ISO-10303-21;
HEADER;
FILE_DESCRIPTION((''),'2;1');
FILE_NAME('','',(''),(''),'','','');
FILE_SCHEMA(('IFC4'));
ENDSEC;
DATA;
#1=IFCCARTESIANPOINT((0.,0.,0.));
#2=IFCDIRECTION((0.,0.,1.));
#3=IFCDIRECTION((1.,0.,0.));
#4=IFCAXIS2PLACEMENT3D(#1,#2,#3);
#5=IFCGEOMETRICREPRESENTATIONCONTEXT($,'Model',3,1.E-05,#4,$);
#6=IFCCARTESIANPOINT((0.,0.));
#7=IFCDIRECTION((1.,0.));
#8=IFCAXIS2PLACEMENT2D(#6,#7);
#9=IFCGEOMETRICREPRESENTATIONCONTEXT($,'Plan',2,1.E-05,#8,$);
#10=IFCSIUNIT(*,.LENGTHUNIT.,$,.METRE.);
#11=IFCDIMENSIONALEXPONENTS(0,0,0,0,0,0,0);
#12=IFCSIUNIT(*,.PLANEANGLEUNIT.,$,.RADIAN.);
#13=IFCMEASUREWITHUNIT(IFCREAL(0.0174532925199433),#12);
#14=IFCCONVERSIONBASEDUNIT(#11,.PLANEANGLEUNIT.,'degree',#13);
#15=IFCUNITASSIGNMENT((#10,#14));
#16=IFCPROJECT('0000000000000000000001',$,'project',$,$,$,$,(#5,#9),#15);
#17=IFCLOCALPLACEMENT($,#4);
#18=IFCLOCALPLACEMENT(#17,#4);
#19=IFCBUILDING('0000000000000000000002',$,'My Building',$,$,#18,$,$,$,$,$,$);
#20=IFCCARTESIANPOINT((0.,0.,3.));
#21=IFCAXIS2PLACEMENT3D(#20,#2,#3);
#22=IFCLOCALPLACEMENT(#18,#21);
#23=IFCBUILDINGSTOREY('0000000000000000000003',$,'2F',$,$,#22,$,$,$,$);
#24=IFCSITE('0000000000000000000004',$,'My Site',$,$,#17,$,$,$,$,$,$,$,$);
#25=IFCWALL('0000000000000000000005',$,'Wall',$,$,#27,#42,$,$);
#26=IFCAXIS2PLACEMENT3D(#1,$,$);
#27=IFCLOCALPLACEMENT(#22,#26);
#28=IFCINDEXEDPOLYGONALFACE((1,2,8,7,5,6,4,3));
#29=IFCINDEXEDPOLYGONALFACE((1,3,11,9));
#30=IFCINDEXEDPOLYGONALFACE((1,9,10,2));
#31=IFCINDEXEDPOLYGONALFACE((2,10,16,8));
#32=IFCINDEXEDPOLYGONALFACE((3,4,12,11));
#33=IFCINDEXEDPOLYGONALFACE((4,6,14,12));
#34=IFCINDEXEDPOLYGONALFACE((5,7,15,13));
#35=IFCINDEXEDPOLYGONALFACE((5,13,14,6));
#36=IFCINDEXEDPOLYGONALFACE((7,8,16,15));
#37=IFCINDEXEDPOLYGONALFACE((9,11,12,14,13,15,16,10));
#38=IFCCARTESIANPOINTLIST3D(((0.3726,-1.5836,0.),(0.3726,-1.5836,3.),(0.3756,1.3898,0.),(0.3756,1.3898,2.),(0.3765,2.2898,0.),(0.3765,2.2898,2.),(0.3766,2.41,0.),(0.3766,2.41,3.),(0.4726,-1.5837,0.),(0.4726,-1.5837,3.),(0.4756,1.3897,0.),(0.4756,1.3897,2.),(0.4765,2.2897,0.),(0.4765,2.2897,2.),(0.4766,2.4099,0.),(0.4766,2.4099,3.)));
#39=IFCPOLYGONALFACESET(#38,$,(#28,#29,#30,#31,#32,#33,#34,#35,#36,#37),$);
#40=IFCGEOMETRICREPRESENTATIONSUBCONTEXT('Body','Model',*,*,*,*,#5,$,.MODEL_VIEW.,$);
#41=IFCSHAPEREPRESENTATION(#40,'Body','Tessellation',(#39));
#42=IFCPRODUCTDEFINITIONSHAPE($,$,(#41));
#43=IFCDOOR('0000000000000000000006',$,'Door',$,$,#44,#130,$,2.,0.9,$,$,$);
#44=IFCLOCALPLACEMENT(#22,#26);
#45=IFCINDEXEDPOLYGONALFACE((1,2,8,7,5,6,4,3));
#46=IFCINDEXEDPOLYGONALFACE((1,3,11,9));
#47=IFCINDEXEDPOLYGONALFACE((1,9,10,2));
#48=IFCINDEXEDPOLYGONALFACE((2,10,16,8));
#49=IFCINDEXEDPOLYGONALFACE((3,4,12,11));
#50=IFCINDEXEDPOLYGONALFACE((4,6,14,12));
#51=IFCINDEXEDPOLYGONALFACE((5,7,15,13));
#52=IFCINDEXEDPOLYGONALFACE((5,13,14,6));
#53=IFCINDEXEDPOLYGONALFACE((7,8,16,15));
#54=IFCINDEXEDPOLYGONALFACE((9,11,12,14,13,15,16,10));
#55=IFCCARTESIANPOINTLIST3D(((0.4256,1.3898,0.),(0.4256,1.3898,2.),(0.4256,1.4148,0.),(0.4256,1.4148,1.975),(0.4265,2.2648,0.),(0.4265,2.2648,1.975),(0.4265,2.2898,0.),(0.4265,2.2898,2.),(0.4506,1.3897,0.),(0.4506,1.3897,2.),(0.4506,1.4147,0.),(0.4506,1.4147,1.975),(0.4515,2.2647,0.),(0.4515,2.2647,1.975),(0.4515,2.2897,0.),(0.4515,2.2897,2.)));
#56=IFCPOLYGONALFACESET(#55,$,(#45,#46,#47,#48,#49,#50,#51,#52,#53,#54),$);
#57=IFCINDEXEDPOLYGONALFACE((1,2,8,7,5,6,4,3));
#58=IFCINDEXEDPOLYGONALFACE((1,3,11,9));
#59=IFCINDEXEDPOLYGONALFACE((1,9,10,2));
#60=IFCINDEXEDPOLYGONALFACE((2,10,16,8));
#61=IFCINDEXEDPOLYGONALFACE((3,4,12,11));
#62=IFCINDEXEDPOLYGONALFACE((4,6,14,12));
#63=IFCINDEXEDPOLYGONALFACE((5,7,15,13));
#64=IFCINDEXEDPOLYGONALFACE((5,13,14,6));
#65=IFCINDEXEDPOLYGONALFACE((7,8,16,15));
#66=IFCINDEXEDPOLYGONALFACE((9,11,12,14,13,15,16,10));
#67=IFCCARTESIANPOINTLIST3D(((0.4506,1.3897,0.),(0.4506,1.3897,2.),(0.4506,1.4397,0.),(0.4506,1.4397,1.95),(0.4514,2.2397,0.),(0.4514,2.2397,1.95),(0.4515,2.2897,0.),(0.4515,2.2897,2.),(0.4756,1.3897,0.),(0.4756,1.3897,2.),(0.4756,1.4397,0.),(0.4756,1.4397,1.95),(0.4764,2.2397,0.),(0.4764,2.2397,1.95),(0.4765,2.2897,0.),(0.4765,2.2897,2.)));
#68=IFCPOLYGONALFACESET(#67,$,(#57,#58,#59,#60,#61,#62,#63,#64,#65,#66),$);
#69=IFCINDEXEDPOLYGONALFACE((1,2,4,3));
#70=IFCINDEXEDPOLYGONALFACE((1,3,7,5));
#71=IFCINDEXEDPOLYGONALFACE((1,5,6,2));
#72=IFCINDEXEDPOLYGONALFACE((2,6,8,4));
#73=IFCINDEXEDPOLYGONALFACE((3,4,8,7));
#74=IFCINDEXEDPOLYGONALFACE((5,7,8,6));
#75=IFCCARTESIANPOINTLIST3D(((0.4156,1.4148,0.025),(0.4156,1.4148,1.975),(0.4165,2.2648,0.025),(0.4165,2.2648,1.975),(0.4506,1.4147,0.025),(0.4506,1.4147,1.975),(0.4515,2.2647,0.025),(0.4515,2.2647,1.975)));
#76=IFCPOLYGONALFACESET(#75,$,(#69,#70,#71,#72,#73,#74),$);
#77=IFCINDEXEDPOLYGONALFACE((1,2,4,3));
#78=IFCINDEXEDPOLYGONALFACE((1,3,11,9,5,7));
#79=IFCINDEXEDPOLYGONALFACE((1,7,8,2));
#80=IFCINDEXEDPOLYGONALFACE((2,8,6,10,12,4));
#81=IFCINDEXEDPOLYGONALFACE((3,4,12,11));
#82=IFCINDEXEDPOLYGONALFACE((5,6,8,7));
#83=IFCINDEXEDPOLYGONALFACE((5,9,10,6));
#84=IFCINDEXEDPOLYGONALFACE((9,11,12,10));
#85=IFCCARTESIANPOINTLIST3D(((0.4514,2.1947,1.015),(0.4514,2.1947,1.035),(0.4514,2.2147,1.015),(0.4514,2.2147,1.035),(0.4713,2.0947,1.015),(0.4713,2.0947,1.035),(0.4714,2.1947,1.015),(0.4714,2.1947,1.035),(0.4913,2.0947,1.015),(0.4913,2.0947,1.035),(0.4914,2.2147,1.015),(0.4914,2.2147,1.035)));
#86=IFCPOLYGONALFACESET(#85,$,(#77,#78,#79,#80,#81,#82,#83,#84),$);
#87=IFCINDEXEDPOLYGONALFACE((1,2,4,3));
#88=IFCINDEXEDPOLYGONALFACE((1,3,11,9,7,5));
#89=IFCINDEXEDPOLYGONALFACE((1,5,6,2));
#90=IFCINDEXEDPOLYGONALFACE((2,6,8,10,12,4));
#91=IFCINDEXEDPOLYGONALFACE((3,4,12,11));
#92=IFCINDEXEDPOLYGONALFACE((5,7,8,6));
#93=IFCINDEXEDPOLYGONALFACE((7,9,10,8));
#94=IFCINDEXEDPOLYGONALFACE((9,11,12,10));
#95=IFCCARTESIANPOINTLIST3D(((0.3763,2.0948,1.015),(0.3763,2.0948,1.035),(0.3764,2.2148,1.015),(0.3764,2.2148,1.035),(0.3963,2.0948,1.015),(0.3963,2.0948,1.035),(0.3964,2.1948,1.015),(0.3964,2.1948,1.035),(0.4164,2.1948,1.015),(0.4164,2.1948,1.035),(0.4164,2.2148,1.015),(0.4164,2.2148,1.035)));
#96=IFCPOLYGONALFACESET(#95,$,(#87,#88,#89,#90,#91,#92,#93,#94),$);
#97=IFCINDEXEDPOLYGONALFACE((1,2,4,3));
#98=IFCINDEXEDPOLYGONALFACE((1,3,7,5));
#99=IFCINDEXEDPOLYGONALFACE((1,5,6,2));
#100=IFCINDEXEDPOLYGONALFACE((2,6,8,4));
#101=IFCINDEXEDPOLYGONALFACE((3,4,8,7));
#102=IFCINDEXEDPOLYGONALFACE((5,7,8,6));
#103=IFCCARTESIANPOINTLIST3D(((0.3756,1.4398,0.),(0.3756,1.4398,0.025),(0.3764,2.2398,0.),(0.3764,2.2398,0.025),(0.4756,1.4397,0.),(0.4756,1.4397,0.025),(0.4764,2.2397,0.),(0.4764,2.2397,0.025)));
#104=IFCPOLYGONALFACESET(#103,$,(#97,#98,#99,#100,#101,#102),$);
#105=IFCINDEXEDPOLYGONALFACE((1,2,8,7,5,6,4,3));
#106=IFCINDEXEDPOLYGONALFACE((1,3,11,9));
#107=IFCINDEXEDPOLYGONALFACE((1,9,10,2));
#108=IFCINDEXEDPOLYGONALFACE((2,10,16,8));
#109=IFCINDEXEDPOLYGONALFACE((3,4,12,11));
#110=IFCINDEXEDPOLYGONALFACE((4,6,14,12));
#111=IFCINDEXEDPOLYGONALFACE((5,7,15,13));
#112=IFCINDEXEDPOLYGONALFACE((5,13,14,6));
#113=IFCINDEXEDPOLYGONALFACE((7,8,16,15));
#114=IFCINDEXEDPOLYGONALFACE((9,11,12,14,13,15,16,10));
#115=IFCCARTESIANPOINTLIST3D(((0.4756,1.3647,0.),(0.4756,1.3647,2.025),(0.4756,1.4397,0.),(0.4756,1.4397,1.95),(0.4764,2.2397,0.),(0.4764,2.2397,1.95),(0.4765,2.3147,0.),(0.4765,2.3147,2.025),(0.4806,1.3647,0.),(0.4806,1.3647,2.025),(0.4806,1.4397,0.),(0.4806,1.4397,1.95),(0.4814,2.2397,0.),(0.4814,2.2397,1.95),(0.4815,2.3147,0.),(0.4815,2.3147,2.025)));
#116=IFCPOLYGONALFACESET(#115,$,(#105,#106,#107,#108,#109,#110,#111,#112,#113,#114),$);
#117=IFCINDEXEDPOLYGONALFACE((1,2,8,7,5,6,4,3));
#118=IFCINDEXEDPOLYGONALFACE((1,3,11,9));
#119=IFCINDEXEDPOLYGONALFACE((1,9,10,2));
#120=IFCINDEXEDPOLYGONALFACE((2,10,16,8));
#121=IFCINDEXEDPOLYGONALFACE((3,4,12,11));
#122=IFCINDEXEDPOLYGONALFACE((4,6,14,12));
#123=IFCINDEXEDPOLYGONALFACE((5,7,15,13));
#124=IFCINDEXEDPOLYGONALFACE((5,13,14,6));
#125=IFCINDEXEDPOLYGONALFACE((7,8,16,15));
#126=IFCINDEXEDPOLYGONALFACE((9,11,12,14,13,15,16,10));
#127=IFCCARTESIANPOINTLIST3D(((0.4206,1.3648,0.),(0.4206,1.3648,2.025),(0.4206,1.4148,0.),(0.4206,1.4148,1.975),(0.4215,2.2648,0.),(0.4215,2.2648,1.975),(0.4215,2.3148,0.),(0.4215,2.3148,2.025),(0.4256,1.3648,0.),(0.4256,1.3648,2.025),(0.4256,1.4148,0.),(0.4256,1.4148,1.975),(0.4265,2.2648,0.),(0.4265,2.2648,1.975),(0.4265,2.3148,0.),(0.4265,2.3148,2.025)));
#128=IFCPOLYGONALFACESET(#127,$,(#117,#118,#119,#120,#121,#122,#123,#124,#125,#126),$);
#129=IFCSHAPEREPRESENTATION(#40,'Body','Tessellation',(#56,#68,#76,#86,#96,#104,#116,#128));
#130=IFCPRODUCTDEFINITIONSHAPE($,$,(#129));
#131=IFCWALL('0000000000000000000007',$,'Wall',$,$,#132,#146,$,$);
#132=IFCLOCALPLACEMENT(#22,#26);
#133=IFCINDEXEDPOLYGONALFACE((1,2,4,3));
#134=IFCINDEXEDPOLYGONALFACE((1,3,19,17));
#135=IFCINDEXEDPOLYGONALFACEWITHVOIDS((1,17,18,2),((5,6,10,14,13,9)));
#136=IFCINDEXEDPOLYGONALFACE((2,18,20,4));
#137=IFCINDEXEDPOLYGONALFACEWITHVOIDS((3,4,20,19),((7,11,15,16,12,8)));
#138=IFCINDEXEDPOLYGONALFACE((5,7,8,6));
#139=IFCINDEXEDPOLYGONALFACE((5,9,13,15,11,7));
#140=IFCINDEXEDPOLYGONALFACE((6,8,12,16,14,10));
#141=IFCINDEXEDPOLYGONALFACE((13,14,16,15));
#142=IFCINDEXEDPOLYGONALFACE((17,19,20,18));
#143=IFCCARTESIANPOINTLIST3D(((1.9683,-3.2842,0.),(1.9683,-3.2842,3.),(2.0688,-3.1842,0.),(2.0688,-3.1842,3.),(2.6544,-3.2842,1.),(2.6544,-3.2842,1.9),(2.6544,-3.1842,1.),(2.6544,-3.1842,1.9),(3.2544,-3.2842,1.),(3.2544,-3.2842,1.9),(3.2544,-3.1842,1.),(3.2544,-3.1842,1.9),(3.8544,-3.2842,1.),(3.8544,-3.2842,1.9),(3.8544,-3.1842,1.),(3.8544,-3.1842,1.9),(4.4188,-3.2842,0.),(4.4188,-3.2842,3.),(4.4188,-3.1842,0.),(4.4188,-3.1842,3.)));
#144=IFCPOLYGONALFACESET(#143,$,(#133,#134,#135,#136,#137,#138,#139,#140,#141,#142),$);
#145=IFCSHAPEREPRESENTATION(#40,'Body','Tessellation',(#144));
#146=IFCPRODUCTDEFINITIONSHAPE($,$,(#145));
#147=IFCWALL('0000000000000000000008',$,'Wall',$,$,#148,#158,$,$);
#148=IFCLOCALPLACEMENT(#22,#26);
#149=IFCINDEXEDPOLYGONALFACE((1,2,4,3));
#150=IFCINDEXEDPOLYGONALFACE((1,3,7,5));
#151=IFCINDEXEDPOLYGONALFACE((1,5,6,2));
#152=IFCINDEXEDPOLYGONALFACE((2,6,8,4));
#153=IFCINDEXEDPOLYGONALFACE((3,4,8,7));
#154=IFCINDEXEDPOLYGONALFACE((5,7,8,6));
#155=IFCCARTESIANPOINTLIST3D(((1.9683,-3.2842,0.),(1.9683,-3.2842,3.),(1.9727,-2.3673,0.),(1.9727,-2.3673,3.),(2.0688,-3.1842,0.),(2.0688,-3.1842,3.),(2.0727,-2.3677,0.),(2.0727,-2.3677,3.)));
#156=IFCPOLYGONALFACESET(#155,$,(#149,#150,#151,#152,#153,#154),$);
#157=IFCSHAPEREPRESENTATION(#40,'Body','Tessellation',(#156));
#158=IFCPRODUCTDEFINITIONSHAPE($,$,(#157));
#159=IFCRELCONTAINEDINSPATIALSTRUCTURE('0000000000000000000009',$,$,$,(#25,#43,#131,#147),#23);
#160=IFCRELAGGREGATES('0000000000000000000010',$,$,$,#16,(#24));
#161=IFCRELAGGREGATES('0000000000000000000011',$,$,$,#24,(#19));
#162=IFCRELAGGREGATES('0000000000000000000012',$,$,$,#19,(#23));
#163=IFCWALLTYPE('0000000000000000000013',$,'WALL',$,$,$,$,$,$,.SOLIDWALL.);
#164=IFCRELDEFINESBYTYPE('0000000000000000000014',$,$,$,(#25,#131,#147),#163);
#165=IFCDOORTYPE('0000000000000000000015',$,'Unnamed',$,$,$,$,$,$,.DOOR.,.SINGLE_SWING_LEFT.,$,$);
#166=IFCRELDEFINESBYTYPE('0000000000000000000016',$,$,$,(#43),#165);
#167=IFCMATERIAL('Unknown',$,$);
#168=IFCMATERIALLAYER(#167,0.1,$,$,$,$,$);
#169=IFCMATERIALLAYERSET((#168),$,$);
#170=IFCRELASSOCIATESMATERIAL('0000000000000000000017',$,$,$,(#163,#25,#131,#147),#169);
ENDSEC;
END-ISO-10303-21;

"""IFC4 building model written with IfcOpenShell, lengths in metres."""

from ifc_helpers import new_model, entity, si_unit, converted_unit, frame, origin_with_axes, origin_2d_with_axis, place, context, subcontext, project, spatial, line, indexed_curve, outline, extrude, shape, source, transform, mapped, material, layer, layer_set, layer_usage, type_object, type_shapes, element, fill, save


model = new_model("IFC4")

# Units and contexts
model_context = context("Model", 3, precision=1e-05, world=origin_with_axes())
plan_context = context("Plan", 2, precision=1e-05, world=origin_2d_with_axis())
body_context_1 = subcontext(model_context, "Body", "Model", "MODEL_VIEW")
body_context_2 = subcontext(plan_context, "Body", "Plan", "PLAN_VIEW")
ifc_project = project(units=[si_unit("LENGTHUNIT", "METRE"), converted_unit("PLANEANGLEUNIT", "degree", entity("IfcReal", 0.0174532925199433), si_unit("PLANEANGLEUNIT", "RADIAN"), dimensions=[0, 0, 0, 0, 0, 0, 0])], contexts=[model_context, plan_context])

# Site, building, storey
site_placement = place(None, origin_with_axes())
site = spatial("IfcSite", under=ifc_project, at=site_placement, Name="My Site")
building_placement = place(site_placement, origin_with_axes())
building = spatial("IfcBuilding", under=site, at=building_placement, Name="My Building")
storey_placement = place(building_placement, frame((0.0, 0.0, 3.0), z_axis=(0.0, 0.0, 1.0), x_axis=(1.0, 0.0, 0.0)))
storey = spatial("IfcBuildingStorey", under=building, at=storey_placement, Name="2F")

# Shared definitions
ifc_material = material(Name="Unknown")

# Shared definitions
ifc_layer = layer(ifc_material, 0.1)
ifc_layer_set = layer_set([ifc_layer])
wall_type = type_object("IfcWallType", Name="WALL", PredefinedType="SOLIDWALL", material=ifc_layer_set)

# Wall, opening, door
ifc_layer_usage_1 = layer_usage(ifc_layer_set, "AXIS2", "POSITIVE", 0.0)
wall_1_placement = place(storey_placement, frame((0.4726, -1.5837, 0.0), z_axis=(0.0, 0.0, 1.0), x_axis=(0.000991, 1.0, 0.0)))
wall_1 = element("IfcWall", 1, at=wall_1_placement, inside=storey, type_object=wall_type, material=ifc_layer_usage_1, Name="Wall", context=body_context_1, shape_type="SweptSolid", body=[
    extrude(outline(indexed_curve([(0.0, 0.0), (0.0, 0.1), (3.9936, 0.1), (3.9936, 0.0)], segments=[line(1, 2, 3, 4, 1)])), origin_with_axes(), (0.0, 0.0, 1.0), 3.0),
])
shared_shape_1 = source(origin_with_axes(), body_context_1, "Body", "SweptSolid", [
    extrude(outline(indexed_curve([(0.0, 0.0), (0.9, 0.0), (0.9, 2.0), (0.0, 2.0)], segments=[line(1, 2, 3, 4, 1)])), frame((0.0, -0.6, 0.0), z_axis=(0.0, -1.0, 0.0), x_axis=(1.0, 0.0, 0.0)), (0.0, 0.0, -1.0), 1.2),
])
opening_1_placement = place(wall_1_placement, frame((2.9734, 0.0, 0.0), z_axis=(0.0, 0.0, 1.0), x_axis=(1.0, 0.0, 0.0)))
opening_1 = element("IfcOpeningElement", 2, at=opening_1_placement, cuts=wall_1, PredefinedType="OPENING", context=body_context_1, shape_type="MappedRepresentation", body=[
    mapped(shared_shape_1, transform((0.0, 0.0, 0.0), x_axis=(1.0, 0.0, 0.0), y_axis=(0.0, 1.0, 0.0), z_axis=(0.0, 0.0, 1.0), scale=1.0)),
])
door_type = type_object("IfcDoorType", Name="Unnamed", OperationType="SINGLE_SWING_LEFT", PredefinedType="DOOR")
shared_shape_2 = source(origin_with_axes(), body_context_1, "Body", "SweptSolid", [
    extrude(outline(indexed_curve([(0.0, 0.0), (0.0, 2.0), (0.9, 2.0), (0.9, 0.0), (0.875, 0.0), (0.875, 1.975), (0.025, 1.975), (0.025, 0.0)], segments=[line(1, 2, 3, 4, 5, 6, 7, 8, 1)])), frame((0.0, 0.025, 0.0), z_axis=(0.0, -1.0, 0.0), x_axis=(1.0, 0.0, 0.0)), (0.0, 0.0, -1.0), 0.025),
    extrude(outline(indexed_curve([(0.0, 0.0), (0.0, 2.0), (0.9, 2.0), (0.9, 0.0), (0.85, 0.0), (0.85, 1.95), (0.05, 1.95), (0.05, 0.0)], segments=[line(1, 2, 3, 4, 5, 6, 7, 8, 1)])), frame((0.0, 0.0, 0.0), z_axis=(0.0, -1.0, 0.0), x_axis=(1.0, 0.0, 0.0)), (0.0, 0.0, -1.0), 0.025),
    extrude(outline(indexed_curve([(0.0, 0.0), (0.85, 0.0), (0.85, 0.035), (0.0, 0.035)], segments=[line(1, 2, 3, 4, 1)])), frame((0.025, 0.025, 0.025), z_axis=(0.0, 0.0, 1.0), x_axis=(1.0, 0.0, 0.0)), (0.0, 0.0, 1.0), 1.95),
    extrude(outline(indexed_curve([(0.0, 0.0), (0.0, -0.04), (-0.12, -0.04), (-0.12, -0.02), (-0.02, -0.02), (-0.02, 0.0)], segments=[line(1, 2, 3, 4, 5, 6, 1)])), frame((0.825, 0.025, 1.015), z_axis=(0.0, 0.0, 1.0), x_axis=(1.0, 0.0, 0.0)), (0.0, 0.0, 1.0), 0.02),
    extrude(outline(indexed_curve([(0.0, 0.0), (0.0, 0.04), (-0.12, 0.04), (-0.12, 0.02), (-0.02, 0.02), (-0.02, 0.0)], segments=[line(1, 2, 3, 4, 5, 6, 1)])), frame((0.825, 0.06, 1.015), z_axis=(0.0, 0.0, 1.0), x_axis=(1.0, 0.0, 0.0)), (0.0, 0.0, 1.0), 0.02),
    extrude(outline(indexed_curve([(0.0, 0.0), (0.8, 0.0), (0.8, 0.1), (0.0, 0.1)], segments=[line(1, 2, 3, 4, 1)])), frame((0.05, 0.0, 0.0), z_axis=(0.0, 0.0, 1.0), x_axis=(1.0, 0.0, 0.0)), (0.0, 0.0, 1.0), 0.025),
    extrude(outline(indexed_curve([(0.0, 0.0), (0.0, 2.025), (0.95, 2.025), (0.95, 0.0), (0.875, 0.0), (0.875, 1.95), (0.075, 1.95), (0.075, 0.0)], segments=[line(1, 2, 3, 4, 5, 6, 7, 8, 1)])), frame((-0.025, -0.005, 0.0), z_axis=(0.0, -1.0, 0.0), x_axis=(1.0, 0.0, 0.0)), (0.0, 0.0, -1.0), 0.005),
    extrude(outline(indexed_curve([(0.0, 0.0), (0.0, 2.025), (0.95, 2.025), (0.95, 0.0), (0.9, 0.0), (0.9, 1.975), (0.05, 1.975), (0.05, 0.0)], segments=[line(1, 2, 3, 4, 5, 6, 7, 8, 1)])), frame((-0.025, 0.05, 0.0), z_axis=(0.0, -1.0, 0.0), x_axis=(1.0, 0.0, 0.0)), (0.0, 0.0, -1.0), 0.005),
])
shared_shape_3 = source(origin_with_axes(), body_context_2, "Body", "Curve2D", [
    entity("IfcIndexedPolyCurve", entity("IfcCartesianPointList2D", [[0.0, 0.0], [0.0, 0.05], [0.025, 0.05], [0.025, 0.025], [0.05, 0.025], [0.05, 0.0]]), [entity("IfcLineIndex", [1, 2, 3, 4, 5, 6, 1])]),
    entity("IfcIndexedPolyCurve", entity("IfcCartesianPointList2D", [[0.9, 0.0], [0.9, 0.05], [0.875, 0.05], [0.875, 0.025], [0.85, 0.025], [0.85, 0.0]]), [entity("IfcLineIndex", [1, 2, 3, 4, 5, 6, 1])]),
    entity("IfcTrimmedCurve", entity("IfcEllipse", entity("IfcAxis2Placement2D", entity("IfcCartesianPoint", [0.06, 0.05]), entity("IfcDirection", [1.0, 0.0])), 0.815, 0.85), [entity("IfcCartesianPoint", [0.875, 0.05])], [entity("IfcCartesianPoint", [0.06, 0.9])], True, "CARTESIAN"),
    entity("IfcIndexedPolyCurve", entity("IfcCartesianPointList2D", [[0.025, 0.05], [0.06, 0.05], [0.06, 0.9], [0.025, 0.9]]), [entity("IfcLineIndex", [1, 2, 3, 4, 1])]),
])
type_shapes(door_type, [shared_shape_2, shared_shape_3])
door_1_placement = place(opening_1_placement, frame((0.0, 0.0, 0.0), z_axis=(0.0, 0.0, 1.0), x_axis=(1.0, 0.0, 0.0)))
door_1 = element("IfcDoor", 3, at=door_1_placement, inside=storey, type_object=door_type, Name="Door", OverallHeight=2.0, OverallWidth=0.9, shapes=[
    shape(body_context_1, "Body", "MappedRepresentation", [mapped(shared_shape_2, transform((0.0, 0.0, 0.0), x_axis=(1.0, 0.0, 0.0), y_axis=(0.0, 1.0, 0.0), z_axis=(0.0, 0.0, 1.0), scale=1.0))]),
    shape(body_context_2, "Body", "MappedRepresentation", [mapped(shared_shape_3, transform((0.0, 0.0, 0.0), x_axis=(1.0, 0.0, 0.0), y_axis=(0.0, 1.0, 0.0), z_axis=(0.0, 0.0, 1.0), scale=1.0))]),
])
fill(opening_1, door_1)

# Wall, openings
ifc_layer_usage_2 = layer_usage(ifc_layer_set, "AXIS2", "POSITIVE", 0.0)
wall_2_placement = place(storey_placement, frame((4.4188, -3.1842, 0.0), z_axis=(0.0, 0.0, 1.0), x_axis=(-1.0, 0.0, 0.0)))
wall_2 = element("IfcWall", 4, at=wall_2_placement, inside=storey, type_object=wall_type, material=ifc_layer_usage_2, Name="Wall", context=body_context_1, shape_type="SweptSolid", body=[
    extrude(outline(indexed_curve([(0.0, 0.0), (0.0, 0.1), (2.4505, 0.1), (2.35, 0.0)], segments=[line(1, 2, 3, 4, 1)])), origin_with_axes(), (0.0, 0.0, 1.0), 3.0),
])
shared_shape_4 = source(origin_with_axes(), body_context_1, "Body", "SweptSolid", [
    extrude(outline(indexed_curve([(0.0, 0.0), (0.6, 0.0), (0.6, 0.9), (0.0, 0.9)], segments=[line(1, 2, 3, 4, 1)])), frame((0.0, -0.6, 0.0), z_axis=(0.0, -1.0, 0.0), x_axis=(1.0, 0.0, 0.0)), (0.0, 0.0, -1.0), 1.2),
])
opening_2_placement = place(wall_2_placement, frame((0.5644, 0.0, 1.0), z_axis=(0.0, 0.0, 1.0), x_axis=(1.0, 0.0, 0.0)))
element("IfcOpeningElement", 5, at=opening_2_placement, cuts=wall_2, PredefinedType="OPENING", context=body_context_1, shape_type="MappedRepresentation", body=[
    mapped(shared_shape_4, transform((0.0, 0.0, 0.0), x_axis=(1.0, 0.0, 0.0), y_axis=(0.0, 1.0, 0.0), z_axis=(0.0, 0.0, 1.0), scale=1.0)),
])
opening_3_placement = place(wall_2_placement, frame((1.1644, 0.0, 1.0), z_axis=(0.0, 0.0, 1.0), x_axis=(1.0, 0.0, 0.0)))
element("IfcOpeningElement", 6, at=opening_3_placement, cuts=wall_2, PredefinedType="OPENING", context=body_context_1, shape_type="MappedRepresentation", body=[
    mapped(shared_shape_4, transform((0.0, 0.0, 0.0), x_axis=(1.0, 0.0, 0.0), y_axis=(0.0, 1.0, 0.0), z_axis=(0.0, 0.0, 1.0), scale=1.0)),
])

# Wall
ifc_layer_usage_3 = layer_usage(ifc_layer_set, "AXIS2", "POSITIVE", 0.0)
wall_3_placement = place(storey_placement, frame((2.0688, -3.1842, 0.0), z_axis=(0.0, 0.0, 1.0), x_axis=(0.00477, 0.999989, 0.0)))
element("IfcWall", 7, at=wall_3_placement, inside=storey, type_object=wall_type, material=ifc_layer_usage_3, Name="Wall", context=body_context_1, shape_type="SweptSolid", body=[
    extrude(outline(indexed_curve([(0.0, 0.0), (-0.1005, 0.1), (0.8165, 0.1), (0.8165, 0.0)], segments=[line(1, 2, 3, 4, 1)])), origin_with_axes(), (0.0, 0.0, 1.0), 3.0),
])

save(model, "model.ifc")
